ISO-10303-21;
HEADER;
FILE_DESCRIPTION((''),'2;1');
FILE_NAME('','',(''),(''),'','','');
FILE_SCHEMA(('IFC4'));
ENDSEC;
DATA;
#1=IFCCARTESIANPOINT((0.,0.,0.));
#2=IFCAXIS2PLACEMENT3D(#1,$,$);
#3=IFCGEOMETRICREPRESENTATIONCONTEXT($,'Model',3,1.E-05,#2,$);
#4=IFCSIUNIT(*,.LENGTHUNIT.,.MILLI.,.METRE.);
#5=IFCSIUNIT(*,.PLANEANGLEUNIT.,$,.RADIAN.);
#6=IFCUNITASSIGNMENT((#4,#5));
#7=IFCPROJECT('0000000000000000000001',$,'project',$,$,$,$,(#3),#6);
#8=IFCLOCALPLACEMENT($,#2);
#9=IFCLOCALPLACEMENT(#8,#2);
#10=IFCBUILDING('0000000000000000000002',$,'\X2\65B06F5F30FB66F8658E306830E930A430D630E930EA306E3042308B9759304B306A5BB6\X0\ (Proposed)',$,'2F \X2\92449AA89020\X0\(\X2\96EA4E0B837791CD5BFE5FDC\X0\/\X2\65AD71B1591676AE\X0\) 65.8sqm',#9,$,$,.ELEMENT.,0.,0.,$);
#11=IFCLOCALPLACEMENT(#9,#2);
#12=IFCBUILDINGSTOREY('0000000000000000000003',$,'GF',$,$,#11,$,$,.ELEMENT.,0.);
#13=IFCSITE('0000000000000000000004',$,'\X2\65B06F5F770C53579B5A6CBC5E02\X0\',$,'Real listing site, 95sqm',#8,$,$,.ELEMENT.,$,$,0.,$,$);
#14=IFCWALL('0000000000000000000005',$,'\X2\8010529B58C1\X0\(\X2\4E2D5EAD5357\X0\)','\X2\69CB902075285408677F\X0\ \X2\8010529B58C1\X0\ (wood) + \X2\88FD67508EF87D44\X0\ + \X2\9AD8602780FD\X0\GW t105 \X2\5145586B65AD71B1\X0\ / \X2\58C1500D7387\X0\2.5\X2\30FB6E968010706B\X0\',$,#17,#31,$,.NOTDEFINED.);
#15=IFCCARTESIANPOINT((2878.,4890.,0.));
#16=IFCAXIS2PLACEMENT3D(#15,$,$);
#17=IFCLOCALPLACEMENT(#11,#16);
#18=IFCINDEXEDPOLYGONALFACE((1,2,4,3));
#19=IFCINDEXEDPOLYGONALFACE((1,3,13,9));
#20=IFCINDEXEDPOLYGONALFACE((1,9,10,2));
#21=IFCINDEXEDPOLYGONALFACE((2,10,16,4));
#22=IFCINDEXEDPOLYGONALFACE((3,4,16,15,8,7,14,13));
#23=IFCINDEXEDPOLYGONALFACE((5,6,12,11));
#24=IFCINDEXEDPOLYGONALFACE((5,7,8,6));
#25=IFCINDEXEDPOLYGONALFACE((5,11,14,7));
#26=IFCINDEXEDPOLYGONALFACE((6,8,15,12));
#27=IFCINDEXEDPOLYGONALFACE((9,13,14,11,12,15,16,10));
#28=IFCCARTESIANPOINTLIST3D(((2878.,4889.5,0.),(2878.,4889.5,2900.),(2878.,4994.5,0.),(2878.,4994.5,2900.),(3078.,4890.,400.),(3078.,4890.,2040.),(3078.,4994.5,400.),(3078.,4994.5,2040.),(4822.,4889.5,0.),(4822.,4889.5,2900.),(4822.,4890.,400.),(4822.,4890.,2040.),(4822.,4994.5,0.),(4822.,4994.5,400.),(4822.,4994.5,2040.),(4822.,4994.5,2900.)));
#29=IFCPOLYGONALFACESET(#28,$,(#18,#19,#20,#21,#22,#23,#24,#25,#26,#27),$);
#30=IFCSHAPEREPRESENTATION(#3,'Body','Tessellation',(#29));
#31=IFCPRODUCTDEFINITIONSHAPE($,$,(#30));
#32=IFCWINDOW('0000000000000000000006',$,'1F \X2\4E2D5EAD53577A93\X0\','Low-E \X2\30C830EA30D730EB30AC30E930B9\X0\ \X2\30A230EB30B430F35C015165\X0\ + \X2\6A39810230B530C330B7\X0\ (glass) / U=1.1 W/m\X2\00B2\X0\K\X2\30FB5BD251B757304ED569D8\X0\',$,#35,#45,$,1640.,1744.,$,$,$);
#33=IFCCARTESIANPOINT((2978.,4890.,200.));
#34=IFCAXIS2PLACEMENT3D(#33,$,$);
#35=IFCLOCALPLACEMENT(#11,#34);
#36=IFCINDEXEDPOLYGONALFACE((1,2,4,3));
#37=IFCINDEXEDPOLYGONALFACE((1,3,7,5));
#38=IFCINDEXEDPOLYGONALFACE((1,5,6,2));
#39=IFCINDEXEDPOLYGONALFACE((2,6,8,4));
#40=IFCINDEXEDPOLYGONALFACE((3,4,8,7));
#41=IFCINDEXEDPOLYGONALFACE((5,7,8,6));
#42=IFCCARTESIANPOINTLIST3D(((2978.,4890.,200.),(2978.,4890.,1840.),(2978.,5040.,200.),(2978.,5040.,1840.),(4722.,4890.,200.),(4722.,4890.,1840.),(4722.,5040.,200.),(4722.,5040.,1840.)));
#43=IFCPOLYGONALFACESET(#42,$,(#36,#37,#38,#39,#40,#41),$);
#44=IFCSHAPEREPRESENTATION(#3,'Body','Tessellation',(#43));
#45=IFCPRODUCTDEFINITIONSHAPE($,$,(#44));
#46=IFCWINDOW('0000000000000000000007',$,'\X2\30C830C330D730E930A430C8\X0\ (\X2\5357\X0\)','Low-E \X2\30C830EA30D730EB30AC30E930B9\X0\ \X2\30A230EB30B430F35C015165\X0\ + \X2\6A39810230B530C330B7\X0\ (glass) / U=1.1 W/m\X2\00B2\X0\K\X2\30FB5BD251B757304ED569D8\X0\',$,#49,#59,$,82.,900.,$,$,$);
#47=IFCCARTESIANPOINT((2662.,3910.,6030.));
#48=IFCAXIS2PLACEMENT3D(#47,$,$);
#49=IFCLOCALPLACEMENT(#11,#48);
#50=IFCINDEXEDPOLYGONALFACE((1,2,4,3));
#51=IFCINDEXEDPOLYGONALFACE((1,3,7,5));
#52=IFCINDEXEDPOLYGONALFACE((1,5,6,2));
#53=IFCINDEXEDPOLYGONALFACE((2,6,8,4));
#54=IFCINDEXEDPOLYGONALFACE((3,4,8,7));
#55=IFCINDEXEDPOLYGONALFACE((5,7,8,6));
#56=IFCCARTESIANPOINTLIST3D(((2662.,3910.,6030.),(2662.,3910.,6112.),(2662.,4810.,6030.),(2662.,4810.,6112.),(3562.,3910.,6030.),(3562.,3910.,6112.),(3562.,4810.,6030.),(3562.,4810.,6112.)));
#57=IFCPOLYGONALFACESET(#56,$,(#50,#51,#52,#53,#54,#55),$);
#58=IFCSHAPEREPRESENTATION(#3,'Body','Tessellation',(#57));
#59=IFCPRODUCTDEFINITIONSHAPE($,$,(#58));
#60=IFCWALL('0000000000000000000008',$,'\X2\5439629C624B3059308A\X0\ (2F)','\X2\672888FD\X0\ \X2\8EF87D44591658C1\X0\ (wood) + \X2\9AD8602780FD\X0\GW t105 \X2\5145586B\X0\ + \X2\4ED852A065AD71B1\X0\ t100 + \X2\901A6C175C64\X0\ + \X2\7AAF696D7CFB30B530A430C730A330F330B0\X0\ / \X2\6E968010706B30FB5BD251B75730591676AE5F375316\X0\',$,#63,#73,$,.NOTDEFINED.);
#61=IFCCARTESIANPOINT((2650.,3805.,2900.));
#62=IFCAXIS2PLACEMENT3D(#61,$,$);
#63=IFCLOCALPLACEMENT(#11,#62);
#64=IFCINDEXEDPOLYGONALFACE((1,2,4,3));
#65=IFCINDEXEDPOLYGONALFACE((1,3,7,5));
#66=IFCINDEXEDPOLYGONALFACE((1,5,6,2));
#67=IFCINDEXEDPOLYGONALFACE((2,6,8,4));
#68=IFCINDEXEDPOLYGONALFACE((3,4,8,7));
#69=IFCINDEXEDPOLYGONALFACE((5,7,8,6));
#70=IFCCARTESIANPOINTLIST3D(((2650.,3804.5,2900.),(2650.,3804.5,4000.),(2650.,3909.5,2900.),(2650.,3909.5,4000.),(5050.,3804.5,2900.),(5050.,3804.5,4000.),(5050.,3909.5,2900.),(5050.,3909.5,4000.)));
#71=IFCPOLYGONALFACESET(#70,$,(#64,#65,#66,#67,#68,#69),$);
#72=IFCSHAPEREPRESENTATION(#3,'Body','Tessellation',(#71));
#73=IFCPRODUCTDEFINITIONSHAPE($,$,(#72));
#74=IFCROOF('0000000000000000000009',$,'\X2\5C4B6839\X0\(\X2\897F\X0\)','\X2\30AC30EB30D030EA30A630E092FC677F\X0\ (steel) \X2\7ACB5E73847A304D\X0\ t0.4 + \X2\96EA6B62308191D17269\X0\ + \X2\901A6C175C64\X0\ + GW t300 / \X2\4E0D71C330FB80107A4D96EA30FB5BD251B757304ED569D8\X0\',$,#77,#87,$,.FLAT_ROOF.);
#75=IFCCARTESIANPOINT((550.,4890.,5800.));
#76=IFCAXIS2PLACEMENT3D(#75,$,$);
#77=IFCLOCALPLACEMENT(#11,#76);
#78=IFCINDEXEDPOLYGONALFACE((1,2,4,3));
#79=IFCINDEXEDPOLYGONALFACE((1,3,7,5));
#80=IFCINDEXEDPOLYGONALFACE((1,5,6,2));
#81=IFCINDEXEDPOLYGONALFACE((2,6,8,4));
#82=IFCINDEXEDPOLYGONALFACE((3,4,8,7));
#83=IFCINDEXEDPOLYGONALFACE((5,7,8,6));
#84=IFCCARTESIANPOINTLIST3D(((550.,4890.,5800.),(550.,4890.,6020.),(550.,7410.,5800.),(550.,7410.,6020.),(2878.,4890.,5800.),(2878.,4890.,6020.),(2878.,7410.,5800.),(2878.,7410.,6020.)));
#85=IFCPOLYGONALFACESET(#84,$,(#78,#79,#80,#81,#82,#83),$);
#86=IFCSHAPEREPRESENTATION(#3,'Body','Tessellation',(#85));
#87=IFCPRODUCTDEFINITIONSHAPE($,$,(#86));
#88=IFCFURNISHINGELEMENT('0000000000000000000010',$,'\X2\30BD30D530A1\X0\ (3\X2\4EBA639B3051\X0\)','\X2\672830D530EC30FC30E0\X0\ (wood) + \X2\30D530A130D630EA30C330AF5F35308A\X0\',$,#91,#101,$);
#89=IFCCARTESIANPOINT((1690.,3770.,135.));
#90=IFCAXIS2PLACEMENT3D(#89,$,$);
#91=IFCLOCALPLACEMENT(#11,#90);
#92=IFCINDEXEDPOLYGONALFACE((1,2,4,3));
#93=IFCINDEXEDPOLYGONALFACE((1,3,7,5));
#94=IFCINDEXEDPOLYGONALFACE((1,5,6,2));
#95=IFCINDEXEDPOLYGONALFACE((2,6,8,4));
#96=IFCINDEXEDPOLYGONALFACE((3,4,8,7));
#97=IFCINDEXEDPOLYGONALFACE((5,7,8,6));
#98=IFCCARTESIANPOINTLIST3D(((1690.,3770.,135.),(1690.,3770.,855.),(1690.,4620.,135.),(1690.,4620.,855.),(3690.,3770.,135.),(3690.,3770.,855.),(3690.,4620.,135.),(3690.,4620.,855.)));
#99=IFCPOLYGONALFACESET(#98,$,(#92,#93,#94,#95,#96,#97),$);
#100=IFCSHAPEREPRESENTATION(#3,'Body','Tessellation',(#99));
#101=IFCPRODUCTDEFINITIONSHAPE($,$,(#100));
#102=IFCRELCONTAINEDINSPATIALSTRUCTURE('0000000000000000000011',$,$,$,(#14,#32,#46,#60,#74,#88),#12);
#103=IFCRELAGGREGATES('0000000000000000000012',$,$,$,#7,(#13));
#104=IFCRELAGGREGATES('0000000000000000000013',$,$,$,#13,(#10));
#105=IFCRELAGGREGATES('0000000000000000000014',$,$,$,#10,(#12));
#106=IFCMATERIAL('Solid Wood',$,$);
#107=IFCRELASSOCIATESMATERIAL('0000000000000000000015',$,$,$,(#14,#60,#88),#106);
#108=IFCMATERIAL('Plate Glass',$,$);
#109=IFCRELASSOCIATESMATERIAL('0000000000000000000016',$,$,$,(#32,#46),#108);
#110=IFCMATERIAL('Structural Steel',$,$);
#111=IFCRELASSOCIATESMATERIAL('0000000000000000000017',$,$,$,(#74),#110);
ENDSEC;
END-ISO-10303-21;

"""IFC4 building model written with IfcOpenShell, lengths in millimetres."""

from ifc_helpers import new_model, si_unit, frame, frame_2d, origin, place, context, project, spatial, rectangle, extrude, material, element, fill, save


model = new_model("IFC4")

# Units and contexts
model_context = context("Model", 3, precision=1e-05, world=origin())
ifc_project = project(units=[si_unit("LENGTHUNIT", "METRE", prefix="MILLI"), si_unit("PLANEANGLEUNIT", "RADIAN")], contexts=[model_context])

# Site, building, storey
site_placement = place(None, origin())
site = spatial("IfcSite", under=ifc_project, at=site_placement, Name="新潟県南魚沼市", ObjectType="Real listing site, 95sqm", CompositionType="ELEMENT", RefElevation=0.0)
building_placement = place(site_placement, origin())
building = spatial("IfcBuilding", under=site, at=building_placement, Name="新潟・書斎とライブラリのある静かな家 (Proposed)", ObjectType="2F 鉄骨造(雪下荷重対応/断熱外皮) 65.8sqm", CompositionType="ELEMENT", ElevationOfRefHeight=0.0, ElevationOfTerrain=0.0)
storey_placement = place(building_placement, origin())
storey = spatial("IfcBuildingStorey", under=building, at=storey_placement, Name="GF", CompositionType="ELEMENT", Elevation=0.0)

# Shared definitions
ifc_material_1 = material(Name="Solid Wood")

# Wall, opening, window
wall_1_placement = place(storey_placement, frame((2878.0, 4890.0, 0.0)))
wall_1 = element("IfcWall", 1, at=wall_1_placement, inside=storey, material=ifc_material_1, Name="耐力壁(中庭南)", Description="構造用合板 耐力壁 (wood) + 製材軸組 + 高性能GW t105 充填断熱 / 壁倍率2.5・準耐火", PredefinedType="NOTDEFINED", context=model_context, shape_type="SweptSolid", body=[
    extrude(rectangle(XDim=1944.0, YDim=105.0, at=frame_2d((972.0, 52.0))), frame((2878.0, 4890.0, 0.0)), (0.0, 0.0, 1.0), 2900.0),
])
opening_placement = place(storey_placement, frame((2978.0, 4890.0, 200.0)))
opening = element("IfcOpeningElement", 2, at=opening_placement, cuts=wall_1, PredefinedType="NOTDEFINED", context=model_context, shape_type="SweptSolid", body=[
    extrude(rectangle(XDim=1744.0, YDim=150.0, at=frame_2d((872.0, 75.0))), frame((2978.0, 4890.0, 200.0)), (0.0, 0.0, 1.0), 1640.0),
])
ifc_material_2 = material(Name="Plate Glass")
window_1_placement = place(storey_placement, frame((2978.0, 4890.0, 200.0)))
window_1 = element("IfcWindow", 3, at=window_1_placement, inside=storey, material=ifc_material_2, Name="1F 中庭南窓", Description="Low-E トリプルガラス アルゴン封入 + 樹脂サッシ (glass) / U=1.1 W/m²K・寒冷地仕様", OverallHeight=1640.0, OverallWidth=1744.0, context=model_context, shape_type="SweptSolid", body=[
    extrude(rectangle(XDim=1744.0, YDim=150.0, at=frame_2d((872.0, 75.0))), frame((2978.0, 4890.0, 200.0)), (0.0, 0.0, 1.0), 1640.0),
])
fill(opening, window_1)

# Window
window_2_placement = place(storey_placement, frame((2662.0, 3910.0, 6030.0)))
element("IfcWindow", 4, at=window_2_placement, inside=storey, material=ifc_material_2, Name="トップライト (南)", Description="Low-E トリプルガラス アルゴン封入 + 樹脂サッシ (glass) / U=1.1 W/m²K・寒冷地仕様", OverallHeight=82.0, OverallWidth=900.0, context=model_context, shape_type="SweptSolid", body=[
    extrude(rectangle(XDim=900.0, YDim=900.0, at=frame_2d((450.0, 450.0))), frame((2662.0, 3910.0, 6030.0)), (0.0, 0.0, 1.0), 82.0),
])

# Wall
wall_2_placement = place(storey_placement, frame((2650.0, 3805.0, 2900.0)))
element("IfcWall", 5, at=wall_2_placement, inside=storey, material=ifc_material_1, Name="吹抜手すり (2F)", Description="木製 軸組外壁 (wood) + 高性能GW t105 充填 + 付加断熱 t100 + 通気層 + 窯業系サイディング / 準耐火・寒冷地外皮強化", PredefinedType="NOTDEFINED", context=model_context, shape_type="SweptSolid", body=[
    extrude(rectangle(XDim=2400.0, YDim=105.0, at=frame_2d((1200.0, 52.0))), frame((2650.0, 3805.0, 2900.0)), (0.0, 0.0, 1.0), 1100.0),
])

# Roof
ifc_material_3 = material(Name="Structural Steel")
for number, where, name in (
    (6, (550.0, 4890.0, 5800.0), "屋根(西)"),
):
    element("IfcRoof", number, at=place(storey_placement, frame(where)), inside=storey, material=ifc_material_3, Name=name, Description="ガルバリウム鋼板 (steel) 立平葺き t0.4 + 雪止め金物 + 通気層 + GW t300 / 不燃・耐積雪・寒冷地仕様", PredefinedType="FLAT_ROOF", context=model_context, shape_type="SweptSolid", body=[
        extrude(rectangle(XDim=2328.0, YDim=2520.0, at=frame_2d((1164.0, 1260.0))), frame((550.0, 4890.0, 5800.0)), (0.0, 0.0, 1.0), 220.0),
    ])

# Furnishing element
furnishing_placement = place(storey_placement, frame((1690.0, 3770.0, 135.0)))
element("IfcFurnishingElement", 7, at=furnishing_placement, inside=storey, material=ifc_material_1, Name="ソファ (3人掛け)", Description="木フレーム (wood) + ファブリック張り", context=model_context, shape_type="SweptSolid", body=[
    extrude(rectangle(XDim=2000.0, YDim=850.0, at=frame_2d((1000.0, 425.0))), frame((1690.0, 3770.0, 135.0)), (0.0, 0.0, 1.0), 720.0),
])

save(model, "model.ifc")
